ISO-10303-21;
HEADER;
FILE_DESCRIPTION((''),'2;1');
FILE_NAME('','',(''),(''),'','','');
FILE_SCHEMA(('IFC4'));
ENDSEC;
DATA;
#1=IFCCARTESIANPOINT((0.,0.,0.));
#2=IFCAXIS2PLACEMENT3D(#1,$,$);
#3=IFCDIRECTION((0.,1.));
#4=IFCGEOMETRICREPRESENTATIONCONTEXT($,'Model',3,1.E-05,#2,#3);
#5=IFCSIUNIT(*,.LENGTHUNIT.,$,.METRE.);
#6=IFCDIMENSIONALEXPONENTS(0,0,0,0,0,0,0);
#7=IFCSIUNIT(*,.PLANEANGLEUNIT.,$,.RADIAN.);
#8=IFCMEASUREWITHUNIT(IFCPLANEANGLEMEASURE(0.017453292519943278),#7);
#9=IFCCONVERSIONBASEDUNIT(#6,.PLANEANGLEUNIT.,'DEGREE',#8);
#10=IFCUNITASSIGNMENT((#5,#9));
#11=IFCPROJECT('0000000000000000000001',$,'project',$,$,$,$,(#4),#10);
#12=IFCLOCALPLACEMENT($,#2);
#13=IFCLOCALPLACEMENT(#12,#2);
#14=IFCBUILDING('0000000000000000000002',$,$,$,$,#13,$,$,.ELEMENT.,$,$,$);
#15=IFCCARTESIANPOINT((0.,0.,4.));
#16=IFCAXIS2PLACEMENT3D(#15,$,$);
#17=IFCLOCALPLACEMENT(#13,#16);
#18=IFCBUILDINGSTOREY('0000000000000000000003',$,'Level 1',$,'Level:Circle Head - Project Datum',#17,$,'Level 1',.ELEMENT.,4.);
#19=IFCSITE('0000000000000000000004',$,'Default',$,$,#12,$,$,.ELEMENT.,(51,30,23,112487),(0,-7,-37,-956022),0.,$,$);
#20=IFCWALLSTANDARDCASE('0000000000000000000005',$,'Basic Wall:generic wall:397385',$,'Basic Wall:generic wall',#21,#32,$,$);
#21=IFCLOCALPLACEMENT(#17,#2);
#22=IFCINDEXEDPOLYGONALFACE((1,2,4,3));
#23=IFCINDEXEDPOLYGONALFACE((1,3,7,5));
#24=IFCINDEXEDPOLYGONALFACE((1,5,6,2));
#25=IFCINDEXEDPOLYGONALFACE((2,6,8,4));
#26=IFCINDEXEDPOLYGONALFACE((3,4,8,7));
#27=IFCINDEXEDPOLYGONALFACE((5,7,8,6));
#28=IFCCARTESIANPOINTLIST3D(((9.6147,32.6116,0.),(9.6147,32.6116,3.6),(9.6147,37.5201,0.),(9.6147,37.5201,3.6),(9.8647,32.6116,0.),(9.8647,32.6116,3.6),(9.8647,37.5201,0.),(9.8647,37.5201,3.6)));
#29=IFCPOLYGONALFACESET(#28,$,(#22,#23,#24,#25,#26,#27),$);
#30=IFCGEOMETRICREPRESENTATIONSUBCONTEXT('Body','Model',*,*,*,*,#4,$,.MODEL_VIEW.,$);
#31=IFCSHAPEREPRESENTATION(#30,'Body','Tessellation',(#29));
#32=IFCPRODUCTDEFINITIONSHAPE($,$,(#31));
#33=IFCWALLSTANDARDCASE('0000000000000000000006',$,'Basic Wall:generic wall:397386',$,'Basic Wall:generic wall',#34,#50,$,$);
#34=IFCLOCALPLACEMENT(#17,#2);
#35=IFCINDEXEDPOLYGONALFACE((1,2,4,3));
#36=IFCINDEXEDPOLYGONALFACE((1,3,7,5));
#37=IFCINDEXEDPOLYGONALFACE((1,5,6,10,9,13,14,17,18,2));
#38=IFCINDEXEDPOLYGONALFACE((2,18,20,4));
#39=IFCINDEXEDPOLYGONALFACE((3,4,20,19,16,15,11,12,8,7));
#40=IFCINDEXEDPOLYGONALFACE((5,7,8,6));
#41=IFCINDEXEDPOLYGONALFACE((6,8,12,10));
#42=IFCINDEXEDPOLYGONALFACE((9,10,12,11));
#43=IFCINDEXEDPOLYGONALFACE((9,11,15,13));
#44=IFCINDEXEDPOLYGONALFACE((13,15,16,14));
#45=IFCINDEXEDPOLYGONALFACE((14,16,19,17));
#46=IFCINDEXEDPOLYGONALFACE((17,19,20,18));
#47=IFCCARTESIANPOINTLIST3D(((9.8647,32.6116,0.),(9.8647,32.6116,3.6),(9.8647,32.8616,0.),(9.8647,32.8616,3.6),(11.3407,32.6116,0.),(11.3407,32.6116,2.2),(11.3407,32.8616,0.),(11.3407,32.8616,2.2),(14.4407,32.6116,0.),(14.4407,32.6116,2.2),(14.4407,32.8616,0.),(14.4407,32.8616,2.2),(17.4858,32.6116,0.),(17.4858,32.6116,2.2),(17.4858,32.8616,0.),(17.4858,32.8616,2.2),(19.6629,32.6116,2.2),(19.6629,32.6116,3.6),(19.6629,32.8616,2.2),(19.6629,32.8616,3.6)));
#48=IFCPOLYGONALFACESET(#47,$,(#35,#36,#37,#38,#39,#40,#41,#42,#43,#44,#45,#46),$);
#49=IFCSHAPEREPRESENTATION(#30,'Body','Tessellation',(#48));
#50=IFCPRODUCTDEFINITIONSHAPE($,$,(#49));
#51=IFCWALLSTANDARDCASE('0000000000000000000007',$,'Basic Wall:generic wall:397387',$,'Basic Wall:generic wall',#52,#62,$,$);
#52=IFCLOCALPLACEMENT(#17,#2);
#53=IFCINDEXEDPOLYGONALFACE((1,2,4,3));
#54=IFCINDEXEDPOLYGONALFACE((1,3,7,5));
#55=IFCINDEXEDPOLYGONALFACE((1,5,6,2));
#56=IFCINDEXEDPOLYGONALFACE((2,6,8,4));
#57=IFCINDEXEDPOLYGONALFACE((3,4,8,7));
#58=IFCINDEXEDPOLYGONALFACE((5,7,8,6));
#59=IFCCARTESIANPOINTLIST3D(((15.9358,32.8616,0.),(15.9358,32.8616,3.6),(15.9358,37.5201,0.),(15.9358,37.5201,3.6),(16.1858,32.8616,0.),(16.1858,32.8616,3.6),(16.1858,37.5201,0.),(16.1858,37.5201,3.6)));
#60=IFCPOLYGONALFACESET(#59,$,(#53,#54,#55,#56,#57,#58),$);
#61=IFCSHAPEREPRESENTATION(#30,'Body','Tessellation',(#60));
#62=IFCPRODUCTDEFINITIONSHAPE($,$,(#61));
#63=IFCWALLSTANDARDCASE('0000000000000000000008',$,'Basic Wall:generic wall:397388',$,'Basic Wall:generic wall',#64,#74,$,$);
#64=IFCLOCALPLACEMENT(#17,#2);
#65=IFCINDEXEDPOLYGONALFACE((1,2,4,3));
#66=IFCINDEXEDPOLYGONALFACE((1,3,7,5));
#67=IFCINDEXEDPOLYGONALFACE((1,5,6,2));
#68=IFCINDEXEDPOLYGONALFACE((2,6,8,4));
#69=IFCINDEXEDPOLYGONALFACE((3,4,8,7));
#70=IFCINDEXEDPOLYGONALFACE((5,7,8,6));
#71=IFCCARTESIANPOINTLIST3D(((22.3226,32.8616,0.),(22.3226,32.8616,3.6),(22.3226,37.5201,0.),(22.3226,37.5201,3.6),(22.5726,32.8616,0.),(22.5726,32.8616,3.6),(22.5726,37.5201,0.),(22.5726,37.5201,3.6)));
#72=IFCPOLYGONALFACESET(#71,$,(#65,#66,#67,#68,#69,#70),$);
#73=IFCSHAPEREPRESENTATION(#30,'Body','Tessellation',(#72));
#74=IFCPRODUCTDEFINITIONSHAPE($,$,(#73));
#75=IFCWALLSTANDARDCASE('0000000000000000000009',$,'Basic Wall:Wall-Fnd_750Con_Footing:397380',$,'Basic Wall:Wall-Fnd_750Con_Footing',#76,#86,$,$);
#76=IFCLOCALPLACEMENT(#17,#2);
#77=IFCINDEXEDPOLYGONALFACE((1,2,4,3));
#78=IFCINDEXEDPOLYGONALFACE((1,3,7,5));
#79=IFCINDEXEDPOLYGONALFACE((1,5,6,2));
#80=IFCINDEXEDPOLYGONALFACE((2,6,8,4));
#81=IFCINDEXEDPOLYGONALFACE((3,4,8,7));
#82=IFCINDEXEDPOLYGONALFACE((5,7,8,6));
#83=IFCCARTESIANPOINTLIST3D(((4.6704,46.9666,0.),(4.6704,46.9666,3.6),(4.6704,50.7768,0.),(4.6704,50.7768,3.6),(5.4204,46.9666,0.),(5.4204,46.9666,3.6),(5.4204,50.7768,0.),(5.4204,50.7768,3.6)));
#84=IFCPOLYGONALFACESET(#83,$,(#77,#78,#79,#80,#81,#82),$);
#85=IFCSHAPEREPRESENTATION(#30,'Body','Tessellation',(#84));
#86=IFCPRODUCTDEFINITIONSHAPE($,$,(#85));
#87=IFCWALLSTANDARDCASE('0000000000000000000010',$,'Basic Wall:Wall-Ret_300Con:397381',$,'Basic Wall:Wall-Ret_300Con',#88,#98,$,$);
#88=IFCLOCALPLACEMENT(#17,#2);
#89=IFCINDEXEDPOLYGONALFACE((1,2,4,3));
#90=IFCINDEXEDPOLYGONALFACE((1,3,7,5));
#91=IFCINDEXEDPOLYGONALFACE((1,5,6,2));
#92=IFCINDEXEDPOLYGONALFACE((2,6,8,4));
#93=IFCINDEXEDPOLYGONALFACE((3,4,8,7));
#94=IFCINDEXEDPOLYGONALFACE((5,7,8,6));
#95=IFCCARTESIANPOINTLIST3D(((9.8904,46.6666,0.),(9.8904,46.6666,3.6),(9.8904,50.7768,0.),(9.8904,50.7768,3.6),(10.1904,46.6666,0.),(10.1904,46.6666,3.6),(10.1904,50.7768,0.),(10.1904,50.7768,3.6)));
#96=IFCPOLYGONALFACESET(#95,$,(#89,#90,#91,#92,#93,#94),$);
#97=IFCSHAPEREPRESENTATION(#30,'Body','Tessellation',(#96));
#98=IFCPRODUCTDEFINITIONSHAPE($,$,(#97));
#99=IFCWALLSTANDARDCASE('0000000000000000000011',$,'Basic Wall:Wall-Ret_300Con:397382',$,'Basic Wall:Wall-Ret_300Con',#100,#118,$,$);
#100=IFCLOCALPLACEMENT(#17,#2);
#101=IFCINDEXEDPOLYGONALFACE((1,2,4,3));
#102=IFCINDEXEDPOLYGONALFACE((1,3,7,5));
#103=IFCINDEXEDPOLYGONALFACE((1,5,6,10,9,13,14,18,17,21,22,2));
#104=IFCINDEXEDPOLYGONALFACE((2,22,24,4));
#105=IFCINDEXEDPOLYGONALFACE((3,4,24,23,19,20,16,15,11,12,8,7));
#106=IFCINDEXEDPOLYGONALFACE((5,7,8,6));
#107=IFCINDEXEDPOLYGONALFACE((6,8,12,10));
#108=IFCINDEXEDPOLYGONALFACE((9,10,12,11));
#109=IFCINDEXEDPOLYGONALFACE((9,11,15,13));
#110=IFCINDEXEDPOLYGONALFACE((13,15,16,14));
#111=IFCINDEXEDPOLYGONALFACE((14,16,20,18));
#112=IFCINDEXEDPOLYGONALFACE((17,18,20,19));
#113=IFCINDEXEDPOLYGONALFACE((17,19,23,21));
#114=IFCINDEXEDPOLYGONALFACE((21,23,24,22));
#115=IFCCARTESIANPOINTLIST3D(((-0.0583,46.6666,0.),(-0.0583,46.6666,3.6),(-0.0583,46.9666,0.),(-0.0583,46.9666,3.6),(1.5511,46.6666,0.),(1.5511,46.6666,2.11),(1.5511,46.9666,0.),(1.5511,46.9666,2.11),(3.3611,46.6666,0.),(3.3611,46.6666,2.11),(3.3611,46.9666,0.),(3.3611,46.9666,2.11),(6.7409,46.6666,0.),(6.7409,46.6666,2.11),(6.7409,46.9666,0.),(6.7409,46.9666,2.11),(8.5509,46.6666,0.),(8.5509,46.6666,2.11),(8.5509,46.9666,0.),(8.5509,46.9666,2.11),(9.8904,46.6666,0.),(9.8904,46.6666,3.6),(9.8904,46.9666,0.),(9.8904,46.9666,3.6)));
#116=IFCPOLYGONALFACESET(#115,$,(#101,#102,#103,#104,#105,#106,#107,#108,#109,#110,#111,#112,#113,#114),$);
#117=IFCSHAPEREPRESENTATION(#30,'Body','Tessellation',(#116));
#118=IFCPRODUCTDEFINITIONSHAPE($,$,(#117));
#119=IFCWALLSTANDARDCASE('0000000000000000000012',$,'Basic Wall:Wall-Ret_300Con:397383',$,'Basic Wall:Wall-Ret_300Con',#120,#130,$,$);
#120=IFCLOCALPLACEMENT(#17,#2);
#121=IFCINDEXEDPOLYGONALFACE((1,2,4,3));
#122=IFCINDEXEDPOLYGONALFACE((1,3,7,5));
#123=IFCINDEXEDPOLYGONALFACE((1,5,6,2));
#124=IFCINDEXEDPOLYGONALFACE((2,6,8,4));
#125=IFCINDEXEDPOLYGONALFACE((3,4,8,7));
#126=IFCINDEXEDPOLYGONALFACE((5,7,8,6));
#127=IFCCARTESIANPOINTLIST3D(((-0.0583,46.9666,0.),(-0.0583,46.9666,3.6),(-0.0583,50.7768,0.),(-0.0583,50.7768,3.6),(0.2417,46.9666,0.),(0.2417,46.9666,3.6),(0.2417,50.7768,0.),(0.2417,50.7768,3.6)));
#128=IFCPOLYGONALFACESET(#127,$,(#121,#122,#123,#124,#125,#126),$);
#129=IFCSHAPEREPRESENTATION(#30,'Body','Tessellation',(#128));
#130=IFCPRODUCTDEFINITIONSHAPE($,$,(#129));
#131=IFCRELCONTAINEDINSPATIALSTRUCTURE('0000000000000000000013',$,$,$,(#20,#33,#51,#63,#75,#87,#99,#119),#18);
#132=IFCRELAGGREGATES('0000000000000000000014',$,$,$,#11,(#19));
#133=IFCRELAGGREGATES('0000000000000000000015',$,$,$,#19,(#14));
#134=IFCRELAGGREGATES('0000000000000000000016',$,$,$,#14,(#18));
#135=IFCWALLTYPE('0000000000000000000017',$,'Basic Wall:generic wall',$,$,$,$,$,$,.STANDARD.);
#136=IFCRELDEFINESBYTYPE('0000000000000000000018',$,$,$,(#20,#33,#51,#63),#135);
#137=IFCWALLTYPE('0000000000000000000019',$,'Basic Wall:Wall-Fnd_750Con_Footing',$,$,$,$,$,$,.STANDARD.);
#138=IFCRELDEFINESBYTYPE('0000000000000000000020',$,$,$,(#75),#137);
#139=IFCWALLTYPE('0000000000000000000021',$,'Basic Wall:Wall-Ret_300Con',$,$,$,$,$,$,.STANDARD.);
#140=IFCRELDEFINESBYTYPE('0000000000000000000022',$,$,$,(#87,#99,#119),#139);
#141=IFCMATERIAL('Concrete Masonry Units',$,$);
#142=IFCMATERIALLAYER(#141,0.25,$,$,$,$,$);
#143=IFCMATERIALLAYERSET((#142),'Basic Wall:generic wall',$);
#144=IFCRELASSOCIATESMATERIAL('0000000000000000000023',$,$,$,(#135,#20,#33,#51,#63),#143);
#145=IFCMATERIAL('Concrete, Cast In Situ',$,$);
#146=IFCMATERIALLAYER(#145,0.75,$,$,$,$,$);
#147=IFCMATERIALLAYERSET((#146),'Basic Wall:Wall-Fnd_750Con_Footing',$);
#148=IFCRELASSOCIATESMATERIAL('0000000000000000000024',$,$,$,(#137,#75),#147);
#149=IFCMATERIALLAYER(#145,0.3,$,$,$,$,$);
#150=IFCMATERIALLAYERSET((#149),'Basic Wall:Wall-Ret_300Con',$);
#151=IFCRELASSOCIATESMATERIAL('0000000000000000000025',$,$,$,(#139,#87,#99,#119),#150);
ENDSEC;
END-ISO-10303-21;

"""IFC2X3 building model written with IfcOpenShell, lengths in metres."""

from ifc_helpers import new_model, entity, si_unit, converted_unit, direction, frame, frame_2d, origin, place, context, subcontext, project, spatial, rectangle, extrude, material, layer, layer_set, layer_usage, type_object, element, save


model = new_model("IFC2X3")

# Units and contexts
model_context = context("Model", 3, precision=1e-05, world=origin(), true_north=direction((0.0, 1.0)))
body_context = subcontext(model_context, "Body", "Model", "MODEL_VIEW")
ifc_project = project(units=[si_unit("LENGTHUNIT", "METRE"), converted_unit("PLANEANGLEUNIT", "DEGREE", entity("IfcPlaneAngleMeasure", 0.017453292519943278), si_unit("PLANEANGLEUNIT", "RADIAN"), dimensions=[0, 0, 0, 0, 0, 0, 0])], contexts=[model_context])

# Site, building, storey
site_placement = place(None, origin())
site = spatial("IfcSite", under=ifc_project, at=site_placement, Name="Default", CompositionType="ELEMENT", RefLatitude=(51, 30, 23, 112487), RefLongitude=(0, -7, -37, -956022), RefElevation=0.0)
building_placement = place(site_placement, origin())
building = spatial("IfcBuilding", under=site, at=building_placement, CompositionType="ELEMENT")
storey_placement = place(building_placement, frame((0.0, 0.0, 4.0)))
storey = spatial("IfcBuildingStorey", under=building, at=storey_placement, Name="Level 1", ObjectType="Level:Circle Head - Project Datum", LongName="Level 1", CompositionType="ELEMENT", Elevation=4.0)

# Shared definitions
ifc_material_1 = material(Name="Concrete Masonry Units")
ifc_layer_1 = layer(ifc_material_1, 0.25)
ifc_layer_set_1 = layer_set([ifc_layer_1], Name="Basic Wall:generic wall")
wall_type_1 = type_object("IfcWallType", Name="Basic Wall:generic wall", PredefinedType="STANDARD", material=ifc_layer_set_1)

# Wall
ifc_layer_usage_1 = layer_usage(ifc_layer_set_1, "AXIS2", "NEGATIVE", 0.125)
wall_1_placement = place(storey_placement, frame((9.7397, 32.6116, 0.0), z_axis=(0.0, 0.0, 1.0), x_axis=(0.0, 1.0, 0.0)))
element("IfcWallStandardCase", 1, at=wall_1_placement, inside=storey, type_object=wall_type_1, material=ifc_layer_usage_1, Name="Basic Wall:generic wall:397385", ObjectType="Basic Wall:generic wall", context=body_context, shape_type="SweptSolid", body=[
    extrude(rectangle(XDim=4.9086, YDim=0.25, at=frame_2d((2.4543, 0.0), x_axis=(-1.0, 0.0))), origin(), (0.0, 0.0, 1.0), 3.6),
])

# Wall, openings
ifc_layer_usage_2 = layer_usage(ifc_layer_set_1, "AXIS2", "NEGATIVE", 0.125)
wall_2_placement = place(storey_placement, frame((19.6629, 32.7366, 0.0), z_axis=(0.0, 0.0, 1.0), x_axis=(-1.0, 0.0, 0.0)))
wall_2 = element("IfcWallStandardCase", 2, at=wall_2_placement, inside=storey, type_object=wall_type_1, material=ifc_layer_usage_2, Name="Basic Wall:generic wall:397386", ObjectType="Basic Wall:generic wall", context=body_context, shape_type="SweptSolid", body=[
    extrude(rectangle(XDim=9.7982, YDim=0.25, at=frame_2d((4.8991, 0.0), x_axis=(-1.0, 0.0))), origin(), (0.0, 0.0, 1.0), 3.6),
])
opening_1_placement = place(wall_2_placement, frame((2.1771, 0.125, 0.0)))
element("IfcOpeningElement", 3, at=opening_1_placement, cuts=wall_2, ObjectType="Opening", context=body_context, shape_type="SweptSolid", body=[
    extrude(rectangle(XDim=2.2, YDim=3.1, at=frame_2d((1.1, 1.55), x_axis=(1.0, 0.0))), frame((0.0, 0.0, 0.0), z_axis=(0.0, -1.0, 0.0), x_axis=(0.0, 0.0, 1.0)), (0.0, 0.0, 1.0), 0.25),
])
opening_2_placement = place(wall_2_placement, frame((8.3222, 0.125, 0.0)))
element("IfcOpeningElement", 4, at=opening_2_placement, cuts=wall_2, ObjectType="Opening", context=body_context, shape_type="SweptSolid", body=[
    extrude(rectangle(XDim=2.2, YDim=3.1, at=frame_2d((1.1, 1.55), x_axis=(1.0, 0.0))), frame((0.0, 0.0, 0.0), z_axis=(0.0, -1.0, 0.0), x_axis=(0.0, 0.0, 1.0)), (0.0, 0.0, 1.0), 0.25),
])

# Walls
ifc_layer_usage_3 = layer_usage(ifc_layer_set_1, "AXIS2", "NEGATIVE", 0.125)
wall_3_placement = place(storey_placement, frame((16.0608, 37.5201, 0.0), z_axis=(0.0, 0.0, 1.0), x_axis=(0.0, -1.0, 0.0)))
element("IfcWallStandardCase", 5, at=wall_3_placement, inside=storey, type_object=wall_type_1, material=ifc_layer_usage_3, Name="Basic Wall:generic wall:397387", ObjectType="Basic Wall:generic wall", context=body_context, shape_type="SweptSolid", body=[
    extrude(rectangle(XDim=4.6586, YDim=0.25, at=frame_2d((2.3293, 0.0), x_axis=(-1.0, 0.0))), origin(), (0.0, 0.0, 1.0), 3.6),
])
ifc_layer_usage_4 = layer_usage(ifc_layer_set_1, "AXIS2", "NEGATIVE", 0.125)
wall_4_placement = place(storey_placement, frame((22.4476, 37.5201, 0.0), z_axis=(0.0, 0.0, 1.0), x_axis=(0.0, -1.0, 0.0)))
element("IfcWallStandardCase", 6, at=wall_4_placement, inside=storey, type_object=wall_type_1, material=ifc_layer_usage_4, Name="Basic Wall:generic wall:397388", ObjectType="Basic Wall:generic wall", context=body_context, shape_type="SweptSolid", body=[
    extrude(rectangle(XDim=4.6586, YDim=0.25, at=frame_2d((2.3293, 0.0), x_axis=(-1.0, 0.0))), origin(), (0.0, 0.0, 1.0), 3.6),
])
ifc_material_2 = material(Name="Concrete, Cast In Situ")
ifc_layer_2 = layer(ifc_material_2, 0.75)
ifc_layer_set_2 = layer_set([ifc_layer_2], Name="Basic Wall:Wall-Fnd_750Con_Footing")
ifc_layer_usage_5 = layer_usage(ifc_layer_set_2, "AXIS2", "NEGATIVE", 0.375)
wall_type_2 = type_object("IfcWallType", Name="Basic Wall:Wall-Fnd_750Con_Footing", PredefinedType="STANDARD", material=ifc_layer_set_2)
wall_5_placement = place(storey_placement, frame((5.0454, 50.7768, 0.0), z_axis=(0.0, 0.0, 1.0), x_axis=(0.0, -1.0, 0.0)))
element("IfcWallStandardCase", 7, at=wall_5_placement, inside=storey, type_object=wall_type_2, material=ifc_layer_usage_5, Name="Basic Wall:Wall-Fnd_750Con_Footing:397380", ObjectType="Basic Wall:Wall-Fnd_750Con_Footing", context=body_context, shape_type="SweptSolid", body=[
    extrude(rectangle(XDim=3.8102, YDim=0.75, at=frame_2d((1.9051, 0.0), x_axis=(-1.0, 0.0))), origin(), (0.0, 0.0, 1.0), 3.6),
])
ifc_layer_3 = layer(ifc_material_2, 0.3)
ifc_layer_set_3 = layer_set([ifc_layer_3], Name="Basic Wall:Wall-Ret_300Con")
ifc_layer_usage_6 = layer_usage(ifc_layer_set_3, "AXIS2", "NEGATIVE", 0.15)
wall_type_3 = type_object("IfcWallType", Name="Basic Wall:Wall-Ret_300Con", PredefinedType="STANDARD", material=ifc_layer_set_3)
wall_6_placement = place(storey_placement, frame((10.0404, 46.6666, 0.0), z_axis=(0.0, 0.0, 1.0), x_axis=(0.0, 1.0, 0.0)))
element("IfcWallStandardCase", 8, at=wall_6_placement, inside=storey, type_object=wall_type_3, material=ifc_layer_usage_6, Name="Basic Wall:Wall-Ret_300Con:397381", ObjectType="Basic Wall:Wall-Ret_300Con", context=body_context, shape_type="SweptSolid", body=[
    extrude(rectangle(XDim=4.1102, YDim=0.3, at=frame_2d((2.0551, 0.0), x_axis=(-1.0, 0.0))), origin(), (0.0, 0.0, 1.0), 3.6),
])

# Wall, openings
ifc_layer_usage_7 = layer_usage(ifc_layer_set_3, "AXIS2", "NEGATIVE", 0.15)
wall_7_placement = place(storey_placement, frame((9.8904, 46.8166, 0.0), z_axis=(0.0, 0.0, 1.0), x_axis=(-1.0, 0.0, 0.0)))
wall_7 = element("IfcWallStandardCase", 9, at=wall_7_placement, inside=storey, type_object=wall_type_3, material=ifc_layer_usage_7, Name="Basic Wall:Wall-Ret_300Con:397382", ObjectType="Basic Wall:Wall-Ret_300Con", context=body_context, shape_type="SweptSolid", body=[
    extrude(rectangle(XDim=9.9487, YDim=0.3, at=frame_2d((4.9744, 0.0), x_axis=(1.0, 0.0))), origin(), (0.0, 0.0, 1.0), 3.6),
])
opening_3_placement = place(wall_7_placement, frame((3.1495, 0.15, 0.0)))
element("IfcOpeningElement", 10, at=opening_3_placement, cuts=wall_7, ObjectType="Opening", context=body_context, shape_type="SweptSolid", body=[
    extrude(rectangle(XDim=2.11, YDim=1.81, at=frame_2d((1.055, 0.905), x_axis=(-1.0, 0.0))), frame((0.0, 0.0, 0.0), z_axis=(0.0, -1.0, 0.0), x_axis=(0.0, 0.0, 1.0)), (0.0, 0.0, 1.0), 0.3),
])
opening_4_placement = place(wall_7_placement, frame((8.3394, 0.15, 0.0)))
element("IfcOpeningElement", 11, at=opening_4_placement, cuts=wall_7, ObjectType="Opening", context=body_context, shape_type="SweptSolid", body=[
    extrude(rectangle(XDim=2.11, YDim=1.81, at=frame_2d((1.055, 0.905), x_axis=(-1.0, 0.0))), frame((0.0, 0.0, 0.0), z_axis=(0.0, -1.0, 0.0), x_axis=(0.0, 0.0, 1.0)), (0.0, 0.0, 1.0), 0.3),
])

# Wall
ifc_layer_usage_8 = layer_usage(ifc_layer_set_3, "AXIS2", "NEGATIVE", 0.15)
wall_8_placement = place(storey_placement, frame((0.0917, 46.9666, 0.0), z_axis=(0.0, 0.0, 1.0), x_axis=(0.0, 1.0, 0.0)))
element("IfcWallStandardCase", 12, at=wall_8_placement, inside=storey, type_object=wall_type_3, material=ifc_layer_usage_8, Name="Basic Wall:Wall-Ret_300Con:397383", ObjectType="Basic Wall:Wall-Ret_300Con", context=body_context, shape_type="SweptSolid", body=[
    extrude(rectangle(XDim=3.8102, YDim=0.3, at=frame_2d((1.9051, 0.0), x_axis=(-1.0, 0.0))), origin(), (0.0, 0.0, 1.0), 3.6),
])

save(model, "model.ifc")
